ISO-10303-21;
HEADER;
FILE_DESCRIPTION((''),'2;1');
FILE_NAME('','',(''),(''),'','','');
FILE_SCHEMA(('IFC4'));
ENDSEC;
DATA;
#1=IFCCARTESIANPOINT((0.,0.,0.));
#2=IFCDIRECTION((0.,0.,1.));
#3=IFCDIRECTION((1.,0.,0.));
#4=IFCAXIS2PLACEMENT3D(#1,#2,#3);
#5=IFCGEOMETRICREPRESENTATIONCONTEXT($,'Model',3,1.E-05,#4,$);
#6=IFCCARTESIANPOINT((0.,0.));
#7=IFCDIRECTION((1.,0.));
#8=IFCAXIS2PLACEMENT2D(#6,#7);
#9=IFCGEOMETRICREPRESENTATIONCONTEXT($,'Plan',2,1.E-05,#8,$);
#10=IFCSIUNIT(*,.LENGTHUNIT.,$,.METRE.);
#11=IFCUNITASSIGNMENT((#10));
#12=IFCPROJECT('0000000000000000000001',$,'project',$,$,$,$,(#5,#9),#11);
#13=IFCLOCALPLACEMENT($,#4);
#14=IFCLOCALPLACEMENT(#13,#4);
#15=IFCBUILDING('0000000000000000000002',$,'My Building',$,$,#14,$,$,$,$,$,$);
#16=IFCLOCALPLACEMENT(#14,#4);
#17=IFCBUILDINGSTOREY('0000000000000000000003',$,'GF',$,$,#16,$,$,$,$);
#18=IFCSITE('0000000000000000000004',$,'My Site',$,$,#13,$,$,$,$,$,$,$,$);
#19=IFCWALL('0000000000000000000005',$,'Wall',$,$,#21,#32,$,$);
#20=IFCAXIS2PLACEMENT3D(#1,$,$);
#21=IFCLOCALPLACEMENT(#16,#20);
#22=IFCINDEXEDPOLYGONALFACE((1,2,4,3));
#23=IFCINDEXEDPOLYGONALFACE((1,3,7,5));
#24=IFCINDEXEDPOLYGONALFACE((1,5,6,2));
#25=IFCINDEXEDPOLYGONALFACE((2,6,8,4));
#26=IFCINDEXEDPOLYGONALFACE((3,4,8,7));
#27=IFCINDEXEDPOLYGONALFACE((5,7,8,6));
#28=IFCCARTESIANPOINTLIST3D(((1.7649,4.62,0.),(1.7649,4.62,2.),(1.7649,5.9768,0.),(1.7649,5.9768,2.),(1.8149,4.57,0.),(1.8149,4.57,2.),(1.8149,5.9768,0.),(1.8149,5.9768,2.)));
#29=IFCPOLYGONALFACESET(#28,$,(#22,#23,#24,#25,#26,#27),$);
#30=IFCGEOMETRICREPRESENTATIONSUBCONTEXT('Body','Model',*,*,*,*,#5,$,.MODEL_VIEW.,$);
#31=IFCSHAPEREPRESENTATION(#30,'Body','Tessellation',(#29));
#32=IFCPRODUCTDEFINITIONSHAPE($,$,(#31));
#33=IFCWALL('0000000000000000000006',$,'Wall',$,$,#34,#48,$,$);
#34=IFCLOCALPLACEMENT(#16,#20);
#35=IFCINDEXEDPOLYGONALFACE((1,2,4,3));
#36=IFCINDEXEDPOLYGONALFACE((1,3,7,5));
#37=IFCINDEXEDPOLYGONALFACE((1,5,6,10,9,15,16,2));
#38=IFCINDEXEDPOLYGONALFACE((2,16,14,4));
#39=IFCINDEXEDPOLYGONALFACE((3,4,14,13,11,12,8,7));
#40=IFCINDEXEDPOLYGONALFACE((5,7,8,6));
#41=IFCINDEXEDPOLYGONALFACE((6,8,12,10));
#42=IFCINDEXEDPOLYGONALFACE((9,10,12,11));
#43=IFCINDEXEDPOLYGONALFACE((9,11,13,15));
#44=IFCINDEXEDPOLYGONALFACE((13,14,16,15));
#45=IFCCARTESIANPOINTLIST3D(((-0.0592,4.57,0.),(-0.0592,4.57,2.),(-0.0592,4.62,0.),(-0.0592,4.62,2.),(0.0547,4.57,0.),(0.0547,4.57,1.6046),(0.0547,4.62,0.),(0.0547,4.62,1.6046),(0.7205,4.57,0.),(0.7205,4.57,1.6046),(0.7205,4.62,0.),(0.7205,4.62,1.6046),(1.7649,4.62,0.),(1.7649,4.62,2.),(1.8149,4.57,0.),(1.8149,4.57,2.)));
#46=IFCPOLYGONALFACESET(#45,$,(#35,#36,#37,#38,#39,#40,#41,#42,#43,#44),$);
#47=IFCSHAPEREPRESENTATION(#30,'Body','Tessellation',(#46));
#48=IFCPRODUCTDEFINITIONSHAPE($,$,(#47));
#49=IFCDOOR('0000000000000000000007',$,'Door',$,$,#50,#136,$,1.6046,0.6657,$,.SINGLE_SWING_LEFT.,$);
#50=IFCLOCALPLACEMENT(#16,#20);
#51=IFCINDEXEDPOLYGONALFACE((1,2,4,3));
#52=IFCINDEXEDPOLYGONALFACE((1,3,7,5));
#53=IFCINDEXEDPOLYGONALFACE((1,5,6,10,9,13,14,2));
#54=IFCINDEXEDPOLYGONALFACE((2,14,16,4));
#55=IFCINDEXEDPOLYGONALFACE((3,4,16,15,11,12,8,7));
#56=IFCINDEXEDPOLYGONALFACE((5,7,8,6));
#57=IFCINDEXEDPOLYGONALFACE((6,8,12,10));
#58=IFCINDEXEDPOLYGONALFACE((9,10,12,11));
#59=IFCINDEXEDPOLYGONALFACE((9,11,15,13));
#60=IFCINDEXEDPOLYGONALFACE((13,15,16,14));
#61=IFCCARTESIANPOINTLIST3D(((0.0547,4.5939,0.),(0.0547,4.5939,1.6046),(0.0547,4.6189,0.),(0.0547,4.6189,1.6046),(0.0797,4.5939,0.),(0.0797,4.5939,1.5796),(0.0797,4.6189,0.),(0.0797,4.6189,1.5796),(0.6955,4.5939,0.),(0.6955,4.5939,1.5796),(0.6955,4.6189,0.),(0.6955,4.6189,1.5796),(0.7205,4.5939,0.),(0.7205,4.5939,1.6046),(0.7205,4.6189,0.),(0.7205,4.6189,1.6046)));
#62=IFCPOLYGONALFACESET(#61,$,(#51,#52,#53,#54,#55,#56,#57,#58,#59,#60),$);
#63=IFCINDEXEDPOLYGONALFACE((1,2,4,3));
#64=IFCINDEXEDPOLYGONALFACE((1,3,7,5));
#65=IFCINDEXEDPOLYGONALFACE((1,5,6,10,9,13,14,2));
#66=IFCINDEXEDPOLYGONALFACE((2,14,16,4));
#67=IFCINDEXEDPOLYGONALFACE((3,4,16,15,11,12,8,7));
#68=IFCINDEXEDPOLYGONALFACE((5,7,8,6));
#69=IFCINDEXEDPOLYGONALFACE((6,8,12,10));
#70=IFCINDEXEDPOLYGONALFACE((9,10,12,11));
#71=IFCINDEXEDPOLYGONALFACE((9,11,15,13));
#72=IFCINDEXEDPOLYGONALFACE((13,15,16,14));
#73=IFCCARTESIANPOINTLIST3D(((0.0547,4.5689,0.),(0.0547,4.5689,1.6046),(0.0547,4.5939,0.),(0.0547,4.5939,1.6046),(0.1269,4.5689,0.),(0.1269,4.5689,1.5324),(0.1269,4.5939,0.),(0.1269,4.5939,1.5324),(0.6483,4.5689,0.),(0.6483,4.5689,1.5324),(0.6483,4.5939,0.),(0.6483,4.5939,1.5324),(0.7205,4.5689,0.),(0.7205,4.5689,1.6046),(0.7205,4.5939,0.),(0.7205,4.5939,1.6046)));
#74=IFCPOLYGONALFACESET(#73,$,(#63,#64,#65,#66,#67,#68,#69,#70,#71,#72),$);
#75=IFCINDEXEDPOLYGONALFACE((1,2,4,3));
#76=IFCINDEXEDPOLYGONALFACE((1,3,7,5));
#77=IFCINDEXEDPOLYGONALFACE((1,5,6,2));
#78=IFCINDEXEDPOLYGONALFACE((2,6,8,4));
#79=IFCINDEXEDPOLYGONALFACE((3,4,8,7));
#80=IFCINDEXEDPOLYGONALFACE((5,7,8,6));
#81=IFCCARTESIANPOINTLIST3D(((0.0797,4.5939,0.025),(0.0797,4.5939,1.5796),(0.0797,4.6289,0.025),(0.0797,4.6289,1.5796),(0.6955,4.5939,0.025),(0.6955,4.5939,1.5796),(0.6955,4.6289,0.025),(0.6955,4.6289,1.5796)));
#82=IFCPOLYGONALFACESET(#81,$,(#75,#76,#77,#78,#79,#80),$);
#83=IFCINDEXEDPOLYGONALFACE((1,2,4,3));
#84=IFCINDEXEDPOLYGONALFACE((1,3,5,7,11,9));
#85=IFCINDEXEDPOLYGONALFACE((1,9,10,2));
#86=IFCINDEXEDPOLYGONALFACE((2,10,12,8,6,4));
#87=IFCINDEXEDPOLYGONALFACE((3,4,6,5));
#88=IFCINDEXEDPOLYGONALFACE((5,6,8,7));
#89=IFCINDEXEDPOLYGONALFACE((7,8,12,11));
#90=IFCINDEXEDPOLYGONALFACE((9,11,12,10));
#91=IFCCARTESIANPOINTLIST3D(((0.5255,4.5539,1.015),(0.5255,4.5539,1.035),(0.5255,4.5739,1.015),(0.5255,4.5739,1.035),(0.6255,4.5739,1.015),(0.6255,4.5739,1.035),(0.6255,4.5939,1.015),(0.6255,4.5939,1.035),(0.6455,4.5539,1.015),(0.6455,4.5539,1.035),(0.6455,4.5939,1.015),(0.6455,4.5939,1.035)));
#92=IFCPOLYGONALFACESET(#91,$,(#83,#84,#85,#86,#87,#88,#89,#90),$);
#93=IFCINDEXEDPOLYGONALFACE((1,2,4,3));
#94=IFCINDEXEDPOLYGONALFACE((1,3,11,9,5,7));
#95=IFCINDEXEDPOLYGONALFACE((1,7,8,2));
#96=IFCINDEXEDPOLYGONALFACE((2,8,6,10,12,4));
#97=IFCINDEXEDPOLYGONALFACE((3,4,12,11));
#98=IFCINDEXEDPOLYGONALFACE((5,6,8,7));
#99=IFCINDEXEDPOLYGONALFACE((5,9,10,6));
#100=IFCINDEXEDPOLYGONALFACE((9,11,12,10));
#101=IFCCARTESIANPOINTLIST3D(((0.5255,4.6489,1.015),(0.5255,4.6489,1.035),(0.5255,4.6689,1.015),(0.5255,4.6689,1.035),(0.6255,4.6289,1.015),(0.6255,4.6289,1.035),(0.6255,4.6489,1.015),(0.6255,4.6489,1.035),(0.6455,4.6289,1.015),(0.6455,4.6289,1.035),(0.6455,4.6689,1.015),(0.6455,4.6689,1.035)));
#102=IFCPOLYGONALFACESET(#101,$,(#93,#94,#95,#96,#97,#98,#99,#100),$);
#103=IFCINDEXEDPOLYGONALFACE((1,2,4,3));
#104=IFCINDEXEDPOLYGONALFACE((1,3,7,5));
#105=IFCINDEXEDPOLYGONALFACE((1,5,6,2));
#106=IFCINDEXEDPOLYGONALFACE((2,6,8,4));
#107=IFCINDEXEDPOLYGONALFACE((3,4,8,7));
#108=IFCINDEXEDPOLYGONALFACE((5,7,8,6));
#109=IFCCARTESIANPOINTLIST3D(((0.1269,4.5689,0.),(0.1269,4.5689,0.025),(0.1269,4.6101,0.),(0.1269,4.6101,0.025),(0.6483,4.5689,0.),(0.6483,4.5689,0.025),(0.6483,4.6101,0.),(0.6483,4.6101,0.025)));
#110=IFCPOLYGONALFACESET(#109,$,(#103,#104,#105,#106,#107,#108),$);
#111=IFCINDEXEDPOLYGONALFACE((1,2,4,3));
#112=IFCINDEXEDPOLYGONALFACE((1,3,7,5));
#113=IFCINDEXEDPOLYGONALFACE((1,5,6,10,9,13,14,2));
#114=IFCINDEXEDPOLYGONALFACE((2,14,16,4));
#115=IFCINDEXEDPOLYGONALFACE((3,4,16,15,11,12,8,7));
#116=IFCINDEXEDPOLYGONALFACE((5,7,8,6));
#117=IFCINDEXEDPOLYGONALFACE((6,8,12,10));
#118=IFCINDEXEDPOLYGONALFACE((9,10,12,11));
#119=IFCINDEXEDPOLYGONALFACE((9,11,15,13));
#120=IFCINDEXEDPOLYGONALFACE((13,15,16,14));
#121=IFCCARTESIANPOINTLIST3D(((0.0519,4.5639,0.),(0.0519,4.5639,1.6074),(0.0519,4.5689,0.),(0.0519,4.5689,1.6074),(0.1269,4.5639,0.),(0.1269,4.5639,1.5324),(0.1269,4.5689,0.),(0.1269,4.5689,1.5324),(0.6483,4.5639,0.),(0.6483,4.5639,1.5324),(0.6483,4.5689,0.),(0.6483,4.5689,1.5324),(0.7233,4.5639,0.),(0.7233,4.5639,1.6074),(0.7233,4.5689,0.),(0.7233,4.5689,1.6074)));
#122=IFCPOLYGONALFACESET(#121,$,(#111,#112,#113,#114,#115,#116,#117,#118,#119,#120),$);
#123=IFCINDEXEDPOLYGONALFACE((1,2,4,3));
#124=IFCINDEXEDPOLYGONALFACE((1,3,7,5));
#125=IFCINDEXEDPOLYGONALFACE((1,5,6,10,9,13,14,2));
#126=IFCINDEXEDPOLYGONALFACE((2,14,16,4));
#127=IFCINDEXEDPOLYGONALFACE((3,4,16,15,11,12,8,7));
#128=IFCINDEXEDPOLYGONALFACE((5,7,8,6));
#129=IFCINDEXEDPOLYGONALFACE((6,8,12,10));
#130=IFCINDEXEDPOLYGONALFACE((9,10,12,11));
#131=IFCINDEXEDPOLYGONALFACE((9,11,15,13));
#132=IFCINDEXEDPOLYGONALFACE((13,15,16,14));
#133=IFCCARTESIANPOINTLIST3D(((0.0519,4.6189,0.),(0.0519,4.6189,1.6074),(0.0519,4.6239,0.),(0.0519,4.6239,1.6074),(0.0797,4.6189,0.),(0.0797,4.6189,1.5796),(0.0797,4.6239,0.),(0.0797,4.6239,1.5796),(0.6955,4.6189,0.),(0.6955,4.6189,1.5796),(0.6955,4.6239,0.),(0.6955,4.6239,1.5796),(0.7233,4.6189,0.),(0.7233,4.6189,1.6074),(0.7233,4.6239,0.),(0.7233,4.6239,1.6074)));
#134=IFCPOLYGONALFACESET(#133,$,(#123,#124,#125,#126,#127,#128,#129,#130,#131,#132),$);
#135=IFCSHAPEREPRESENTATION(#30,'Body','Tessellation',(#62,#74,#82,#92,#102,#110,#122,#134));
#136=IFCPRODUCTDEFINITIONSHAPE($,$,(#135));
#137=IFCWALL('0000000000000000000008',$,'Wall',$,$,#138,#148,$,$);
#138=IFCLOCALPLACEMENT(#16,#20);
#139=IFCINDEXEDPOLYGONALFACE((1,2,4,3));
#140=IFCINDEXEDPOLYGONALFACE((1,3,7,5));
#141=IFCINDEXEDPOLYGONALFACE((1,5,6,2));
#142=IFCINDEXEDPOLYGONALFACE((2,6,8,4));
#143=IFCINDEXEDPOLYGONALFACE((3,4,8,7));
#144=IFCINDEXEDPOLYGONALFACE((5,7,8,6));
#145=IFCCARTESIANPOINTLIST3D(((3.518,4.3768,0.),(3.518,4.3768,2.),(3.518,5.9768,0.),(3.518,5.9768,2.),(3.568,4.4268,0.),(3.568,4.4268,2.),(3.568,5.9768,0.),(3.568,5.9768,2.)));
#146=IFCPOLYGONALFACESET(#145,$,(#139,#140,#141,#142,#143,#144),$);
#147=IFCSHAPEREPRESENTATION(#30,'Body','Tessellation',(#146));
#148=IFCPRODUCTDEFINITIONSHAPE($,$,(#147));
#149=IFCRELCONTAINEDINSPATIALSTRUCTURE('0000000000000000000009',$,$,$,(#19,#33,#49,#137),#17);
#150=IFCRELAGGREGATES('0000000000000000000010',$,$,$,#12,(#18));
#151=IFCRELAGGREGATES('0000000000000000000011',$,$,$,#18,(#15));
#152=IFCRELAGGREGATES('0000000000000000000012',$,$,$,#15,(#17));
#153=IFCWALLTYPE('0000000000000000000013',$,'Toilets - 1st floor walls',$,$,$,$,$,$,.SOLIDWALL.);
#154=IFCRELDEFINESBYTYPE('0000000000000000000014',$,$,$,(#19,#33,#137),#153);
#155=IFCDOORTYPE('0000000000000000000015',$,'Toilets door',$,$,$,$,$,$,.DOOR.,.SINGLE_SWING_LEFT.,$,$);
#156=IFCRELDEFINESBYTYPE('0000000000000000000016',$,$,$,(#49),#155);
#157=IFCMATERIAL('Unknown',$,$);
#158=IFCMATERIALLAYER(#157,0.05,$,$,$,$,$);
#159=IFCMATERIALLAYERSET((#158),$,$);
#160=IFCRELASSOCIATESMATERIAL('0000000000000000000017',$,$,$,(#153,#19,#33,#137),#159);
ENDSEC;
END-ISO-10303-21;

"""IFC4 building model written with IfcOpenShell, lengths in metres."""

from ifc_helpers import new_model, entity, si_unit, frame, origin_with_axes, origin_2d_with_axis, place, context, subcontext, project, spatial, line, indexed_curve, outline, extrude, shape, source, transform, mapped, material, layer, layer_set, layer_usage, type_object, type_shapes, element, fill, save


model = new_model("IFC4")

# Units and contexts
model_context = context("Model", 3, precision=1e-05, world=origin_with_axes())
plan_context = context("Plan", 2, precision=1e-05, world=origin_2d_with_axis())
body_context_1 = subcontext(model_context, "Body", "Model", "MODEL_VIEW")
body_context_2 = subcontext(plan_context, "Body", "Plan", "PLAN_VIEW")
ifc_project = project(units=[si_unit("LENGTHUNIT", "METRE")], contexts=[model_context, plan_context])

# Site, building, storey
site_placement = place(None, origin_with_axes())
site = spatial("IfcSite", under=ifc_project, at=site_placement, Name="My Site")
building_placement = place(site_placement, origin_with_axes())
building = spatial("IfcBuilding", under=site, at=building_placement, Name="My Building")
storey_placement = place(building_placement, origin_with_axes())
storey = spatial("IfcBuildingStorey", under=building, at=storey_placement, Name="GF")

# Shared definitions
ifc_material = material(Name="Unknown")

# Wall
ifc_layer_1 = layer(ifc_material, 0.05)
ifc_layer_set_1 = layer_set([ifc_layer_1])
wall_type_1 = type_object("IfcWallType", Name="Toilets - 1st floor walls", PredefinedType="SOLIDWALL", material=ifc_layer_set_1)
ifc_layer_usage_1 = layer_usage(ifc_layer_set_1, "AXIS2", "POSITIVE", 0.0)
wall_1_placement = place(storey_placement, frame((1.7649, 5.9768, 0.0), z_axis=(0.0, 0.0, 1.0), x_axis=(0.0, -1.0, 0.0)))
element("IfcWall", 1, at=wall_1_placement, inside=storey, type_object=wall_type_1, material=ifc_layer_usage_1, Name="Wall", context=body_context_1, shape_type="SweptSolid", body=[
    extrude(outline(indexed_curve([(0.0, 0.0), (0.0, 0.05), (1.4068, 0.05), (1.3568, 0.0)], segments=[line(1, 2, 3, 4, 1)])), origin_with_axes(), (0.0, 0.0, 1.0), 2.0),
])

# Wall, opening, door
ifc_layer_usage_2 = layer_usage(ifc_layer_set_1, "AXIS2", "POSITIVE", 0.0)
wall_2_placement = place(storey_placement, frame((-0.2092, 4.57, 0.0), z_axis=(0.0, 0.0, 1.0), x_axis=(1.0, 0.0, 0.0)))
wall_2 = element("IfcWall", 2, at=wall_2_placement, inside=storey, type_object=wall_type_1, material=ifc_layer_usage_2, Name="Wall", context=body_context_1, shape_type="SweptSolid", body=[
    extrude(outline(indexed_curve([(0.15, 0.0), (0.15, 0.05), (1.9742, 0.05), (2.0242, 0.0)], segments=[line(1, 2, 3, 4, 1)])), origin_with_axes(), (0.0, 0.0, 1.0), 2.0),
])
shared_shape_1 = source(origin_with_axes(), body_context_1, "Body", "SweptSolid", [
    extrude(outline(indexed_curve([(0.0, 0.0), (0.6657, 0.0), (0.6657, 1.6046), (0.0, 1.6046)], segments=[line(1, 2, 3, 4, 1)])), frame((0.0, -0.6, 0.0), z_axis=(0.0, -1.0, 0.0), x_axis=(1.0, 0.0, 0.0)), (0.0, 0.0, -1.0), 1.2),
])
opening_1_placement = place(wall_2_placement, frame((0.264, -0.0011, 0.0), z_axis=(0.0, 0.0, 1.0), x_axis=(1.0, 0.0, 0.0)))
opening_1 = element("IfcOpeningElement", 3, at=opening_1_placement, cuts=wall_2, PredefinedType="OPENING", context=body_context_1, shape_type="MappedRepresentation", body=[
    mapped(shared_shape_1, transform((0.0, 0.0, 0.0), x_axis=(1.0, 0.0, 0.0), y_axis=(0.0, 1.0, 0.0), z_axis=(0.0, 0.0, 1.0), scale=1.0)),
])
door_type_1 = type_object("IfcDoorType", Name="Toilets door", OperationType="SINGLE_SWING_LEFT", PredefinedType="DOOR")
shared_shape_2 = source(origin_with_axes(), body_context_1, "Body", "SweptSolid", [
    extrude(outline(indexed_curve([(0.0, 0.0), (0.0, 1.6046), (0.6657, 1.6046), (0.6657, 0.0), (0.6407, 0.0), (0.6407, 1.5796), (0.025, 1.5796), (0.025, 0.0)], segments=[line(1, 2, 3, 4, 5, 6, 7, 8, 1)])), frame((0.0, 0.025, 0.0), z_axis=(0.0, -1.0, 0.0), x_axis=(1.0, 0.0, 0.0)), (0.0, 0.0, -1.0), 0.025),
    extrude(outline(indexed_curve([(0.0, 0.0), (0.0, 1.6046), (0.6657, 1.6046), (0.6657, 0.0), (0.5935, 0.0), (0.5935, 1.5324), (0.0722, 1.5324), (0.0722, 0.0)], segments=[line(1, 2, 3, 4, 5, 6, 7, 8, 1)])), frame((0.0, 0.0, 0.0), z_axis=(0.0, -1.0, 0.0), x_axis=(1.0, 0.0, 0.0)), (0.0, 0.0, -1.0), 0.025),
    extrude(outline(indexed_curve([(0.0, 0.0), (0.6157, 0.0), (0.6157, 0.035), (0.0, 0.035)], segments=[line(1, 2, 3, 4, 1)])), frame((0.025, 0.025, 0.025), z_axis=(0.0, 0.0, 1.0), x_axis=(1.0, 0.0, 0.0)), (0.0, 0.0, 1.0), 1.5546),
    extrude(outline(indexed_curve([(0.0, 0.0), (0.0, -0.04), (-0.12, -0.04), (-0.12, -0.02), (-0.02, -0.02), (-0.02, 0.0)], segments=[line(1, 2, 3, 4, 5, 6, 1)])), frame((0.5907, 0.025, 1.015), z_axis=(0.0, 0.0, 1.0), x_axis=(1.0, 0.0, 0.0)), (0.0, 0.0, 1.0), 0.02),
    extrude(outline(indexed_curve([(0.0, 0.0), (0.0, 0.04), (-0.12, 0.04), (-0.12, 0.02), (-0.02, 0.02), (-0.02, 0.0)], segments=[line(1, 2, 3, 4, 5, 6, 1)])), frame((0.5907, 0.06, 1.015), z_axis=(0.0, 0.0, 1.0), x_axis=(1.0, 0.0, 0.0)), (0.0, 0.0, 1.0), 0.02),
    extrude(outline(indexed_curve([(0.0, 0.0), (0.5214, 0.0), (0.5214, 0.0412), (0.0, 0.0412)], segments=[line(1, 2, 3, 4, 1)])), frame((0.0722, 0.0, 0.0), z_axis=(0.0, 0.0, 1.0), x_axis=(1.0, 0.0, 0.0)), (0.0, 0.0, 1.0), 0.025),
    extrude(outline(indexed_curve([(0.0, 0.0), (0.0, 1.6074), (0.6714, 1.6074), (0.6714, 0.0), (0.5964, 0.0), (0.5964, 1.5324), (0.075, 1.5324), (0.075, 0.0)], segments=[line(1, 2, 3, 4, 5, 6, 7, 8, 1)])), frame((-0.0028, -0.005, 0.0), z_axis=(0.0, -1.0, 0.0), x_axis=(1.0, 0.0, 0.0)), (0.0, 0.0, -1.0), 0.005),
    extrude(outline(indexed_curve([(0.0, 0.0), (0.0, 1.6074), (0.6714, 1.6074), (0.6714, 0.0), (0.6435, 0.0), (0.6435, 1.5796), (0.0278, 1.5796), (0.0278, 0.0)], segments=[line(1, 2, 3, 4, 5, 6, 7, 8, 1)])), frame((-0.0028, 0.05, 0.0), z_axis=(0.0, -1.0, 0.0), x_axis=(1.0, 0.0, 0.0)), (0.0, 0.0, -1.0), 0.005),
])
shared_shape_3 = source(origin_with_axes(), body_context_2, "Body", "Curve2D", [
    entity("IfcIndexedPolyCurve", entity("IfcCartesianPointList2D", [[0.0, 0.0], [0.0, 0.05], [0.025, 0.05], [0.025, 0.025], [0.0722, 0.025], [0.0722, 0.0]]), [entity("IfcLineIndex", [1, 2, 3, 4, 5, 6, 1])]),
    entity("IfcIndexedPolyCurve", entity("IfcCartesianPointList2D", [[0.6657, 0.0], [0.6657, 0.05], [0.6407, 0.05], [0.6407, 0.025], [0.5935, 0.025], [0.5935, 0.0]]), [entity("IfcLineIndex", [1, 2, 3, 4, 5, 6, 1])]),
    entity("IfcTrimmedCurve", entity("IfcEllipse", entity("IfcAxis2Placement2D", entity("IfcCartesianPoint", [0.06, 0.05]), entity("IfcDirection", [1.0, 0.0])), 0.5807, 0.6157), [entity("IfcCartesianPoint", [0.6407, 0.05])], [entity("IfcCartesianPoint", [0.06, 0.6657])], True, "CARTESIAN"),
    entity("IfcIndexedPolyCurve", entity("IfcCartesianPointList2D", [[0.025, 0.05], [0.06, 0.05], [0.06, 0.6657], [0.025, 0.6657]]), [entity("IfcLineIndex", [1, 2, 3, 4, 1])]),
])
type_shapes(door_type_1, [shared_shape_2, shared_shape_3])
door_1_placement = place(opening_1_placement, origin_with_axes())
door_1 = element("IfcDoor", 4, at=door_1_placement, inside=storey, type_object=door_type_1, Name="Door", OperationType="SINGLE_SWING_LEFT", OverallHeight=1.6046, OverallWidth=0.6657, shapes=[
    shape(body_context_1, "Body", "MappedRepresentation", [mapped(shared_shape_2, transform((0.0, 0.0, 0.0), x_axis=(1.0, 0.0, 0.0), y_axis=(0.0, 1.0, 0.0), z_axis=(0.0, 0.0, 1.0), scale=1.0))]),
    shape(body_context_2, "Body", "MappedRepresentation", [mapped(shared_shape_3, transform((0.0, 0.0, 0.0), x_axis=(1.0, 0.0, 0.0), y_axis=(0.0, 1.0, 0.0), z_axis=(0.0, 0.0, 1.0), scale=1.0))]),
])
fill(opening_1, door_1)

# Wall
ifc_layer_usage_3 = layer_usage(ifc_layer_set_1, "AXIS2", "POSITIVE", 0.0)
wall_3_placement = place(storey_placement, frame((3.518, 5.9768, 0.0), z_axis=(0.0, 0.0, 1.0), x_axis=(0.0, -1.0, 0.0)))
element("IfcWall", 5, at=wall_3_placement, inside=storey, type_object=wall_type_1, material=ifc_layer_usage_3, Name="Wall", context=body_context_1, shape_type="SweptSolid", body=[
    extrude(outline(indexed_curve([(0.0, 0.0), (0.0, 0.05), (1.55, 0.05), (1.6, 0.0)], segments=[line(1, 2, 3, 4, 1)])), origin_with_axes(), (0.0, 0.0, 1.0), 2.0),
])

save(model, "model.ifc")
